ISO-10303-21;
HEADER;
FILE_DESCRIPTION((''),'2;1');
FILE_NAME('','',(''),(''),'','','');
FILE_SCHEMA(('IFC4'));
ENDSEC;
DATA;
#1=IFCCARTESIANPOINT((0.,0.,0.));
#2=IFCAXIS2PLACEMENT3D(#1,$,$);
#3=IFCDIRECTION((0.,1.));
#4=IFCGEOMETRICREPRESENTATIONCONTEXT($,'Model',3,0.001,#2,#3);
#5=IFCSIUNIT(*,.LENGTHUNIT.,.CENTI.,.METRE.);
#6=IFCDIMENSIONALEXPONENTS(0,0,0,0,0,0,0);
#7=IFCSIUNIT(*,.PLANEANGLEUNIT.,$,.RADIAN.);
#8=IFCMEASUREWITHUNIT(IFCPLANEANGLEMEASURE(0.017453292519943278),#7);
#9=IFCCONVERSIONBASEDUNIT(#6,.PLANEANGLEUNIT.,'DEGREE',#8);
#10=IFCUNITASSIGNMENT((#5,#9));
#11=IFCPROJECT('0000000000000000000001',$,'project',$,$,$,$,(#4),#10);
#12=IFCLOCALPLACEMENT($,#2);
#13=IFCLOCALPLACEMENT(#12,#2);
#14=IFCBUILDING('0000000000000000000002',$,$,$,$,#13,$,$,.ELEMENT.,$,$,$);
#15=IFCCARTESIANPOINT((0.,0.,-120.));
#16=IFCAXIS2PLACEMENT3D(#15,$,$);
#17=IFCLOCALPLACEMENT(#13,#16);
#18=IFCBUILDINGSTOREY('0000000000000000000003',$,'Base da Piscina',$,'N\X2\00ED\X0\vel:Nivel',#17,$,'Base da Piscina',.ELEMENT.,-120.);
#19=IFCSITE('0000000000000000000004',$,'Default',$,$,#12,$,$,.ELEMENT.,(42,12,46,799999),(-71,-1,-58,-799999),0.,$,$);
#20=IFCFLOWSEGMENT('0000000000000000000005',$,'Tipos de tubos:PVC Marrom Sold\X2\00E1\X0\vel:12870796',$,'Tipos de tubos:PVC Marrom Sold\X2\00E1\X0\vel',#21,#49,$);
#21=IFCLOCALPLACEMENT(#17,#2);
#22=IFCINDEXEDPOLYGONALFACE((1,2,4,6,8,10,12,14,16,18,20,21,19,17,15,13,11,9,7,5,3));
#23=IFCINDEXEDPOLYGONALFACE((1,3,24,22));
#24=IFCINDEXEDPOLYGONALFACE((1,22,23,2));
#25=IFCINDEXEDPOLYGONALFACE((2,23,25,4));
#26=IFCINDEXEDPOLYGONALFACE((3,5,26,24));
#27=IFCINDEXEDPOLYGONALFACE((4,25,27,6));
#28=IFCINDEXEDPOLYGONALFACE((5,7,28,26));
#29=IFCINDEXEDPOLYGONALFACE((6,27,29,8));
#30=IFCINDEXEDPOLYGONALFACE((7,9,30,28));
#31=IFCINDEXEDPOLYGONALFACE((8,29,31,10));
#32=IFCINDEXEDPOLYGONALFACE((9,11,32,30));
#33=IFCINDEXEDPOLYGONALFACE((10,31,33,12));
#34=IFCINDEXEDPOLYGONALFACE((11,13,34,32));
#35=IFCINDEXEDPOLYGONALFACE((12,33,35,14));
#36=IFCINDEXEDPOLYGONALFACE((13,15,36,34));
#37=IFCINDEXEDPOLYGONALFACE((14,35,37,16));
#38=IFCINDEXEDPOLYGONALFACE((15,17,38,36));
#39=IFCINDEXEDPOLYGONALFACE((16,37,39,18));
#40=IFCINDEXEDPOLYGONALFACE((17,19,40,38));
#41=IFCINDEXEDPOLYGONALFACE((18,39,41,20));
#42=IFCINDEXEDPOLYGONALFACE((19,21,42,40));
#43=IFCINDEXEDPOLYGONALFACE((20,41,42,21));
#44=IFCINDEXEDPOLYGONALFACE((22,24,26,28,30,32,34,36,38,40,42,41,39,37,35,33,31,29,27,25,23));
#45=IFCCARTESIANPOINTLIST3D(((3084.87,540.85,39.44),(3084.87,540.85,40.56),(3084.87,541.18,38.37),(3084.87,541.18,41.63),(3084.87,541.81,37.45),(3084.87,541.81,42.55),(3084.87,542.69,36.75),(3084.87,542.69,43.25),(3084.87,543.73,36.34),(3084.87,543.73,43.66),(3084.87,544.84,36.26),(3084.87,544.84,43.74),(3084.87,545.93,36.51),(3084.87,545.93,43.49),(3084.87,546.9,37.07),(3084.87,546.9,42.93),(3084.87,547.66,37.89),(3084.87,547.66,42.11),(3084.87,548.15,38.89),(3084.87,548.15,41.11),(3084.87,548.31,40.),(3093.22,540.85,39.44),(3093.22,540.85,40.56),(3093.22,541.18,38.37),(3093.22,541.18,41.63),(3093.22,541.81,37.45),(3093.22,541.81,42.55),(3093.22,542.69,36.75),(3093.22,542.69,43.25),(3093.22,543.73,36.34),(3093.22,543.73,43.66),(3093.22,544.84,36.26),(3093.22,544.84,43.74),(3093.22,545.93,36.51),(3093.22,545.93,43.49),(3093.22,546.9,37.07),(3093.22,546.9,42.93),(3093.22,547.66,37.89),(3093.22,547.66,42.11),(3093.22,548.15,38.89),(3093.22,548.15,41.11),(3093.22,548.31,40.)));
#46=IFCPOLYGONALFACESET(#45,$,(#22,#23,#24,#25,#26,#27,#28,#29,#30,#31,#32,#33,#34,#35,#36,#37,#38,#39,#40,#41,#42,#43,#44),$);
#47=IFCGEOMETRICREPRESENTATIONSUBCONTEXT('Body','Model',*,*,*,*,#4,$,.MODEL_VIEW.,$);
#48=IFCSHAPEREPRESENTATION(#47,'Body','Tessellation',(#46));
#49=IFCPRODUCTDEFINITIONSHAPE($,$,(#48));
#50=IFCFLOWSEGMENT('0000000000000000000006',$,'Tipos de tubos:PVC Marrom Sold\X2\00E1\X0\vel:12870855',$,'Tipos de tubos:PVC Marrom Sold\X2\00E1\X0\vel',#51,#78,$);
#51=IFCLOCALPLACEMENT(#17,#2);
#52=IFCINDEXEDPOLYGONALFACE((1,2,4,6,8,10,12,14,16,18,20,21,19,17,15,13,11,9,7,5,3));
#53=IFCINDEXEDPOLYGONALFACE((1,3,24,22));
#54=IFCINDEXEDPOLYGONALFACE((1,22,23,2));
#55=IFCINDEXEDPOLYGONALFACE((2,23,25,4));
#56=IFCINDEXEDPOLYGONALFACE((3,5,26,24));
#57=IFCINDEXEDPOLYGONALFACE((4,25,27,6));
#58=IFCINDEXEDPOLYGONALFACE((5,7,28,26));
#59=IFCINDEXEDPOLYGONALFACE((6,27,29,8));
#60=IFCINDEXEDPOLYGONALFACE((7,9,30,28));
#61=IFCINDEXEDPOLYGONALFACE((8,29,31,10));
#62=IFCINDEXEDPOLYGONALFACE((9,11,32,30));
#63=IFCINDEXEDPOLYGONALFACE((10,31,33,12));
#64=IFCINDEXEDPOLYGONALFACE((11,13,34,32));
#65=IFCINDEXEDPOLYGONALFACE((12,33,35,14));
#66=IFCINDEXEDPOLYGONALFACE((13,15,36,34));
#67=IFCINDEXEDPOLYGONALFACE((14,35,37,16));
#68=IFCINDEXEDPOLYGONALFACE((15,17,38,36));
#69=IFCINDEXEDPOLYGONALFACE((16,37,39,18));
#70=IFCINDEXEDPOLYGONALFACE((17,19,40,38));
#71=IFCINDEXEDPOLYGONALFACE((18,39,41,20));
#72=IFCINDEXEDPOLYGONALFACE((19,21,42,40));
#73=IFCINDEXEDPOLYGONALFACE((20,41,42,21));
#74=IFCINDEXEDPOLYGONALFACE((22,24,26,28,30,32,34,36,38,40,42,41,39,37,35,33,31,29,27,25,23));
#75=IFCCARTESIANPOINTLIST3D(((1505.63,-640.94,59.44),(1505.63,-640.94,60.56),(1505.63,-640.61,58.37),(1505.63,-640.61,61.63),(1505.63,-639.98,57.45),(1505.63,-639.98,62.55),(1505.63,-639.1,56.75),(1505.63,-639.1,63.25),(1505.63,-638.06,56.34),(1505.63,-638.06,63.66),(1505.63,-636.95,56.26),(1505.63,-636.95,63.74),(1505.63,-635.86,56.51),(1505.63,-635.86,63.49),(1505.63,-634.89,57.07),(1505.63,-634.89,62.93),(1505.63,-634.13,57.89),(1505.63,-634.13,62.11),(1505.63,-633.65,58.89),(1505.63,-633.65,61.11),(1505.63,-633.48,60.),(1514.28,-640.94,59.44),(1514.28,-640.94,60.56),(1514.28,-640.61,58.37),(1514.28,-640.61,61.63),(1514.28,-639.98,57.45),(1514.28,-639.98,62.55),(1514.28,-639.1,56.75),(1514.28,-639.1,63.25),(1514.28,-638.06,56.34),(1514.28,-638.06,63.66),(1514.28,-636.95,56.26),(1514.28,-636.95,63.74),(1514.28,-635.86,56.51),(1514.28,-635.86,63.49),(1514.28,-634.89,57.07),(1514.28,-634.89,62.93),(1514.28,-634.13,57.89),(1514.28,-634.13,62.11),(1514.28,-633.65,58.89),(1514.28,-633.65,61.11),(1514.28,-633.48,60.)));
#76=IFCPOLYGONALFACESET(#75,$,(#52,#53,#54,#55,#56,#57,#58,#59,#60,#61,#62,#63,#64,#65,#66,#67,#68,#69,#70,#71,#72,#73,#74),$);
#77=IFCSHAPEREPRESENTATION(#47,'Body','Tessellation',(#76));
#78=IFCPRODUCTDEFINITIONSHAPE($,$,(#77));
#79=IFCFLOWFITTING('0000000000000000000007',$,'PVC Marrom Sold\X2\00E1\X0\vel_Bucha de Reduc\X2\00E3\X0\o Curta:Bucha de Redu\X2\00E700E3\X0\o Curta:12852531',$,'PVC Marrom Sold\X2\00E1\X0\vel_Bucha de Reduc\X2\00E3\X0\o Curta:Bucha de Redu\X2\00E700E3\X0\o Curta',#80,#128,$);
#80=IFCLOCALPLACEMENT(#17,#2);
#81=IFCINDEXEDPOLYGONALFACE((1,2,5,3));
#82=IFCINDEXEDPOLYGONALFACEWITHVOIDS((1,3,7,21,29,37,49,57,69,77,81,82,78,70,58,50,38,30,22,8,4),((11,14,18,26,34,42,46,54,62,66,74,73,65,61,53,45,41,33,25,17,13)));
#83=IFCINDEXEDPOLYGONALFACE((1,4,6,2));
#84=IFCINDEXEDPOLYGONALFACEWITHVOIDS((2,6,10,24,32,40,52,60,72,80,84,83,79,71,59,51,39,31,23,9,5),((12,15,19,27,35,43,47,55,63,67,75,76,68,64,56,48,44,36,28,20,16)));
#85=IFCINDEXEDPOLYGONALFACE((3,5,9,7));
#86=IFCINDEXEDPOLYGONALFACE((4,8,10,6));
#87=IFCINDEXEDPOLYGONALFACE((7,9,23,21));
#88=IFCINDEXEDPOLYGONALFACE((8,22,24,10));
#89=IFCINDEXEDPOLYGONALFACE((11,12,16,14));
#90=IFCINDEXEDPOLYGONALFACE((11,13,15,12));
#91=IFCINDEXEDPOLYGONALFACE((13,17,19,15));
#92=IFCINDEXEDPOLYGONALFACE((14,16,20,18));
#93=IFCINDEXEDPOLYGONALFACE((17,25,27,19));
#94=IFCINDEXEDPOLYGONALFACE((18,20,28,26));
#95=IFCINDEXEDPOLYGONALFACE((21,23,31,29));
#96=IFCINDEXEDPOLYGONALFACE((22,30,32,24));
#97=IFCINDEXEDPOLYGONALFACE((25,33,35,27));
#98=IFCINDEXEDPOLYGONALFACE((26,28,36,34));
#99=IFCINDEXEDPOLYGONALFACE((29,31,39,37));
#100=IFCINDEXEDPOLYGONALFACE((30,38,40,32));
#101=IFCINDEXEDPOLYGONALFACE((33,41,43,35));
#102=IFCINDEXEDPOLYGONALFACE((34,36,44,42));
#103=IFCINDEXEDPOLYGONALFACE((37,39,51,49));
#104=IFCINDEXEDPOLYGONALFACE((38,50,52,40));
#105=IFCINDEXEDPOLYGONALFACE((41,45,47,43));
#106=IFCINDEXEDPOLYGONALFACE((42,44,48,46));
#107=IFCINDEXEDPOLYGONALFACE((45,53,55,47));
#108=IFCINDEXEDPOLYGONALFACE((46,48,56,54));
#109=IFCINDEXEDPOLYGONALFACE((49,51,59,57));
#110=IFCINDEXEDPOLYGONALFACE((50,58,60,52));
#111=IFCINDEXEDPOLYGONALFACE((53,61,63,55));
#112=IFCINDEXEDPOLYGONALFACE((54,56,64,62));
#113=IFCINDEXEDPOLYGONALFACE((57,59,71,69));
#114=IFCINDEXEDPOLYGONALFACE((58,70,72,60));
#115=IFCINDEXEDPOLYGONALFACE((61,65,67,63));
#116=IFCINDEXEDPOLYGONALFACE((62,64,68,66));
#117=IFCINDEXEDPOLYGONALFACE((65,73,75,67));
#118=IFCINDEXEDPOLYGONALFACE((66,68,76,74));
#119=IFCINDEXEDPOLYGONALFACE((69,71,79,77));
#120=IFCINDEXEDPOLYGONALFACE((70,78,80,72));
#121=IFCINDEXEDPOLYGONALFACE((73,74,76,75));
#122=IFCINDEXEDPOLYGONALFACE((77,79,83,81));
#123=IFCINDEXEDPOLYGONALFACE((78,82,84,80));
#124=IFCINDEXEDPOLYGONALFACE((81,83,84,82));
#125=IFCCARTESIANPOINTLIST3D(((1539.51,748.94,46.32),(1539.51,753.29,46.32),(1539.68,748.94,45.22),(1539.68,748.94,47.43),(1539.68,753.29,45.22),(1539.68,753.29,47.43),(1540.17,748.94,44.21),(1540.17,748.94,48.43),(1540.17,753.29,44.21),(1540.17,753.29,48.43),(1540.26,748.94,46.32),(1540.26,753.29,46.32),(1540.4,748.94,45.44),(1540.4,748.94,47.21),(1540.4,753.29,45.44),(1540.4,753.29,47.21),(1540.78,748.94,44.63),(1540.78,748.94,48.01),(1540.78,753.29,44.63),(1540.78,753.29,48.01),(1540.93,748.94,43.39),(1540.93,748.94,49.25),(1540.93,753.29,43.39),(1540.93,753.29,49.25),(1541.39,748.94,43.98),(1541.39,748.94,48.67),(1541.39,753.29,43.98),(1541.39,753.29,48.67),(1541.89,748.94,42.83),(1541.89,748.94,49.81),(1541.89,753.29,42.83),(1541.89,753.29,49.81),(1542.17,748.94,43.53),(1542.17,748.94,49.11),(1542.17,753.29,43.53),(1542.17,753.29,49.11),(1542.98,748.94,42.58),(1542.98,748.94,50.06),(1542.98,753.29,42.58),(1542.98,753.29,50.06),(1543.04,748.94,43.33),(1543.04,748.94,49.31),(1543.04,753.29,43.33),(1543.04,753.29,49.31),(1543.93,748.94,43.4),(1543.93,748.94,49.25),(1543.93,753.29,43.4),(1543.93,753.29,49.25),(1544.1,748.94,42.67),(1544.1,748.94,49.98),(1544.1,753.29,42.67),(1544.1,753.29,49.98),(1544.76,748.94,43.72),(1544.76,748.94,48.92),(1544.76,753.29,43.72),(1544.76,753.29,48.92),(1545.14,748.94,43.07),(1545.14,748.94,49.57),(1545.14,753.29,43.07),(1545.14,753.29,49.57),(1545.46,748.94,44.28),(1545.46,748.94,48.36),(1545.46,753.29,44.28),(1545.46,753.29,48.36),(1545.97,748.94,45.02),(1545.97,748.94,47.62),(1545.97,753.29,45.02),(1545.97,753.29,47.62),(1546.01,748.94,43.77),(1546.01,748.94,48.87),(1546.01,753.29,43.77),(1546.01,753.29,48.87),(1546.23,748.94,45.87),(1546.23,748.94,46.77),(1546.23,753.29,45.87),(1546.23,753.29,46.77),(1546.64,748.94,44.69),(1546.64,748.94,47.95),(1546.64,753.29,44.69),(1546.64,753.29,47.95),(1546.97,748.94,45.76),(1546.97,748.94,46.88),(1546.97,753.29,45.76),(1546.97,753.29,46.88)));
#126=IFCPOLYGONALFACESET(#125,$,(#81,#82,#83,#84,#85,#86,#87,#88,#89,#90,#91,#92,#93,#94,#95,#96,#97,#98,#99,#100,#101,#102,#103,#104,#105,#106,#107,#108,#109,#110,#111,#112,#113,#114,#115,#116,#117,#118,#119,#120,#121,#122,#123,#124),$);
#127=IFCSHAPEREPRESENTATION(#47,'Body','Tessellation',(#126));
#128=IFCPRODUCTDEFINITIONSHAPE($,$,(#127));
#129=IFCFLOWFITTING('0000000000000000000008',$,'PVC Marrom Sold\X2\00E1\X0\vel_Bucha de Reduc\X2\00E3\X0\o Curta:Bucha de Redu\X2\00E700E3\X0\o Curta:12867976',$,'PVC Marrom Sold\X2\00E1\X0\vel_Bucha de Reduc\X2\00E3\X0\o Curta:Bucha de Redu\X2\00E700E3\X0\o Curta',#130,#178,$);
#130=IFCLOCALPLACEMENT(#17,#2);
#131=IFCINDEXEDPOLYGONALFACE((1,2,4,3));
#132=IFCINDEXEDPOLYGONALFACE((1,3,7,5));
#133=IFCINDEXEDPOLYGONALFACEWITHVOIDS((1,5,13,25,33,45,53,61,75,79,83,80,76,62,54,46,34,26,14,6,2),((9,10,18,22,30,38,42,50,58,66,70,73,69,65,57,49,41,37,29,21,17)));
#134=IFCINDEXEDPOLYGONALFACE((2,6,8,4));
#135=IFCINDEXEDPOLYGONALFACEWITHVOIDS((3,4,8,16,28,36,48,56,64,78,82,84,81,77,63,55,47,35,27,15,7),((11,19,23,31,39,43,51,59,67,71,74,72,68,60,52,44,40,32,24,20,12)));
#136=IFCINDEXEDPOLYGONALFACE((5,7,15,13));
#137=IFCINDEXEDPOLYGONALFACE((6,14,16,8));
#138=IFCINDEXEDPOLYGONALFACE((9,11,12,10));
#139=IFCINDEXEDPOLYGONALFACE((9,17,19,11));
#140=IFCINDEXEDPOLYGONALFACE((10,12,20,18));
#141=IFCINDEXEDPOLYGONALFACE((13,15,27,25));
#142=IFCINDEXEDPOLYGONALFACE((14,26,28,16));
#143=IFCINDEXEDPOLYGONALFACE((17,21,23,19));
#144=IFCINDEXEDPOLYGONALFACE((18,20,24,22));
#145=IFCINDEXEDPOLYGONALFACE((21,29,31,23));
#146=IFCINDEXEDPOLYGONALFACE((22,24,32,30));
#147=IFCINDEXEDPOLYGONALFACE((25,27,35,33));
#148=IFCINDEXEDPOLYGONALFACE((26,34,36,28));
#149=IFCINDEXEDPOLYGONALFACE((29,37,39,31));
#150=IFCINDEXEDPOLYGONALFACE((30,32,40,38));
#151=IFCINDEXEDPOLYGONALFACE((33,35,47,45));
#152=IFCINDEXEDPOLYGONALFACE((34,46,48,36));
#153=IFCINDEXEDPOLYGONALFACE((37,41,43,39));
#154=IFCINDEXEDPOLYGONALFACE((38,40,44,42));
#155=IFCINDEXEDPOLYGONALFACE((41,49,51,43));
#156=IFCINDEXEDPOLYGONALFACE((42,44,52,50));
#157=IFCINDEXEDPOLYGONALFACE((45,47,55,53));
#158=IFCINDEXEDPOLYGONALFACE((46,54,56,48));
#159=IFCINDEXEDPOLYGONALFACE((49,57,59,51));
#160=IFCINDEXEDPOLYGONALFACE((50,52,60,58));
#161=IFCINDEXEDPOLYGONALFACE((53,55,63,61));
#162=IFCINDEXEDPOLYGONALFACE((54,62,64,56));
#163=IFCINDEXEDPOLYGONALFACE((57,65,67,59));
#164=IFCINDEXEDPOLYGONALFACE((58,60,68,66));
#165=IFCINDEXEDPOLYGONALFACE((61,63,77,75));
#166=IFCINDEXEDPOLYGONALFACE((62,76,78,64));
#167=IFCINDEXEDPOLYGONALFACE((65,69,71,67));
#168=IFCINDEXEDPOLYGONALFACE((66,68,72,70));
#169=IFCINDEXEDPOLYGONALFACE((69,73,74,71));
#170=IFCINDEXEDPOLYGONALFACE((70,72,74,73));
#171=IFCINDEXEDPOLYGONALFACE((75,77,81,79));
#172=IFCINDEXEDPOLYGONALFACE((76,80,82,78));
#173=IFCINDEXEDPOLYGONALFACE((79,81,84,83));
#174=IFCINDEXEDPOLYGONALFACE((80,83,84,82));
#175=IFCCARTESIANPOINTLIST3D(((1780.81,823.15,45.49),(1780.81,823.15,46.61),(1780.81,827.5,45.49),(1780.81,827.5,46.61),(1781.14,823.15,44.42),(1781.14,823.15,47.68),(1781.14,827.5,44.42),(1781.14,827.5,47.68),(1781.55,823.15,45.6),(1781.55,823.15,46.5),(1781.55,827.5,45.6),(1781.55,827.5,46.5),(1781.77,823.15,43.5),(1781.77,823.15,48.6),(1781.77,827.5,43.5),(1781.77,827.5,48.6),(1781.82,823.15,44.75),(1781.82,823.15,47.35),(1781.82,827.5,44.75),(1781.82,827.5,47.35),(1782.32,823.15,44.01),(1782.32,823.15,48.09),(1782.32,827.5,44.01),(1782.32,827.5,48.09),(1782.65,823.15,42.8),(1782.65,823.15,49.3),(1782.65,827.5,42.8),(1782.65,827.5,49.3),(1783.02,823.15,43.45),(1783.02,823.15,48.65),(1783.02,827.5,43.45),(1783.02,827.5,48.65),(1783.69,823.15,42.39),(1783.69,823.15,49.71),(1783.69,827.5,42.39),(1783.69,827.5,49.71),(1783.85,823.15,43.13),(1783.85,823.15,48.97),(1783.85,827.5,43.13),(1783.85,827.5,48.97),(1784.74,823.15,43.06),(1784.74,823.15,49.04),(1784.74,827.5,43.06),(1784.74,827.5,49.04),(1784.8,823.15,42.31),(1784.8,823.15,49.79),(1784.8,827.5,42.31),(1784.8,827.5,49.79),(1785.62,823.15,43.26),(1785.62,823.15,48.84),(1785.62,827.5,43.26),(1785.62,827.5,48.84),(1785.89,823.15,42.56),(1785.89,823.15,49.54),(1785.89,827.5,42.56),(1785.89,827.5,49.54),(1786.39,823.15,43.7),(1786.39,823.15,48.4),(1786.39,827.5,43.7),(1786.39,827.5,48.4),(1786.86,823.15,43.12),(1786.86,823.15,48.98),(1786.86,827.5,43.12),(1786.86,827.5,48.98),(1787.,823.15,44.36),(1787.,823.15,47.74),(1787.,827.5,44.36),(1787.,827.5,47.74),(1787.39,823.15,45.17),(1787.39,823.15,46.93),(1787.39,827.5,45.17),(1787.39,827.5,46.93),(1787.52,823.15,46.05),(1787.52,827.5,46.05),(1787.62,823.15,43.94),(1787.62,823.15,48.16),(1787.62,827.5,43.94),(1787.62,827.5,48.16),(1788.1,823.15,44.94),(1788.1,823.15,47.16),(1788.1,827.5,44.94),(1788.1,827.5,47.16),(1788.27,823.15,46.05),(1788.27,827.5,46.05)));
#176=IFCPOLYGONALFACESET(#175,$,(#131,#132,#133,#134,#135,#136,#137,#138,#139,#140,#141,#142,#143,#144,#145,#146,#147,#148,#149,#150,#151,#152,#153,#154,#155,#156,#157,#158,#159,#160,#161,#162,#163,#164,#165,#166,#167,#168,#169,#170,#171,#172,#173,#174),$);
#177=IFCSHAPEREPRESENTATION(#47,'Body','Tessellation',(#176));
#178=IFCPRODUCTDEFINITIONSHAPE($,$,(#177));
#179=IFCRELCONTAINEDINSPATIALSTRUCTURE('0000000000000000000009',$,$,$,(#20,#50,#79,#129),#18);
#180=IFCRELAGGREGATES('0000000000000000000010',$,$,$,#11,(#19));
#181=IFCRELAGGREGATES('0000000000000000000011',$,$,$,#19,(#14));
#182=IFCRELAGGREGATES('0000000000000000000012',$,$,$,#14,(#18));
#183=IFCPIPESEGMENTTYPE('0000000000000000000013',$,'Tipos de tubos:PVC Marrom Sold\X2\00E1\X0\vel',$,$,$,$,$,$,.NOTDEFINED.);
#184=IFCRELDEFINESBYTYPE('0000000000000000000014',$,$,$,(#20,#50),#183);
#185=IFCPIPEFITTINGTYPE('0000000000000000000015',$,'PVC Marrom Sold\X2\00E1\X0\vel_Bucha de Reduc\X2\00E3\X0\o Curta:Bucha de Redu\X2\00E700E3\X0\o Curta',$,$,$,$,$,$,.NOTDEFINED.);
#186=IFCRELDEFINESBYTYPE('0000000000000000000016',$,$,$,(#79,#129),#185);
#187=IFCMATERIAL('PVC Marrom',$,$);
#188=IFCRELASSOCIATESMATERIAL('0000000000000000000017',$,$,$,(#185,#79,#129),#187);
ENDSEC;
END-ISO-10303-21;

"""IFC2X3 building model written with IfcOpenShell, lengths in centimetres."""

from ifc_helpers import new_model, entity, si_unit, converted_unit, direction, frame, frame_2d, origin, origin_2d_with_axis, place, context, subcontext, project, spatial, circle, hollow_circle, extrude, source, transform, mapped, material, type_object, type_shapes, element, save


model = new_model("IFC2X3")

# Units and contexts
model_context = context("Model", 3, precision=0.001, world=origin(), true_north=direction((0.0, 1.0)))
body_context = subcontext(model_context, "Body", "Model", "MODEL_VIEW")
ifc_project = project(units=[si_unit("LENGTHUNIT", "METRE", prefix="CENTI"), converted_unit("PLANEANGLEUNIT", "DEGREE", entity("IfcPlaneAngleMeasure", 0.017453292519943278), si_unit("PLANEANGLEUNIT", "RADIAN"), dimensions=[0, 0, 0, 0, 0, 0, 0])], contexts=[model_context])

# Site, building, storey
site_placement = place(None, origin())
site = spatial("IfcSite", under=ifc_project, at=site_placement, Name="Default", CompositionType="ELEMENT", RefLatitude=(42, 12, 46, 799999), RefLongitude=(-71, -1, -58, -799999), RefElevation=0.0)
building_placement = place(site_placement, origin())
building = spatial("IfcBuilding", under=site, at=building_placement, CompositionType="ELEMENT")
storey_placement = place(building_placement, frame((0.0, 0.0, -120.0)))
storey = spatial("IfcBuildingStorey", under=building, at=storey_placement, Name="Base da Piscina", ObjectType="Nível:Nivel", LongName="Base da Piscina", CompositionType="ELEMENT", Elevation=-120.0)

# Flow segments
pipe_segment_type = type_object("IfcPipeSegmentType", Name="Tipos de tubos:PVC Marrom Soldável", PredefinedType="NOTDEFINED")
flow_segment_1_placement = place(storey_placement, origin())
element("IfcFlowSegment", 1, at=flow_segment_1_placement, inside=storey, type_object=pipe_segment_type, Name="Tipos de tubos:PVC Marrom Soldável:12870796", ObjectType="Tipos de tubos:PVC Marrom Soldável", context=body_context, shape_type="SweptSolid", body=[
    extrude(circle(Radius=3.75, at=origin_2d_with_axis()), frame((3084.87, 544.56, 40.0), z_axis=(1.0, 0.0, 0.0), x_axis=(0.0, 1.0, 0.0)), (0.0, 0.0, 1.0), 8.35),
])
flow_segment_2_placement = place(storey_placement, origin())
element("IfcFlowSegment", 2, at=flow_segment_2_placement, inside=storey, type_object=pipe_segment_type, Name="Tipos de tubos:PVC Marrom Soldável:12870855", ObjectType="Tipos de tubos:PVC Marrom Soldável", context=body_context, shape_type="SweptSolid", body=[
    extrude(circle(Radius=3.75, at=origin_2d_with_axis()), frame((1505.63, -637.23, 60.0), z_axis=(1.0, 0.0, 0.0), x_axis=(0.0, 1.0, 0.0)), (0.0, 0.0, 1.0), 8.65),
])

# Flow fittings
ifc_material_1 = material(Name="PVC Marrom")
pipe_fitting_type_1 = type_object("IfcPipeFittingType", Name="PVC Marrom Soldável_Bucha de Reducão Curta:Bucha de Redução Curta", PredefinedType="NOTDEFINED", material=ifc_material_1)
shared_shape_1 = source(origin(), body_context, "Body", "SweptSolid", [
    extrude(hollow_circle(Radius=3.75, WallThickness=0.75, at=frame_2d((0.0, 0.0), x_axis=(1.0, 0.0))), frame((0.0, 0.0, 0.0), z_axis=(1.0, 0.0, 0.0), x_axis=(0.0, 1.0, 0.0)), (0.0, 0.0, 1.0), 4.35),
])
type_shapes(pipe_fitting_type_1, [shared_shape_1])
for number, where, z_axis, x_axis, name in (
    (3, (1543.26, 748.94, 46.32), (0.0, 0.0, 1.0), (0.0, 1.0, 0.0), "PVC Marrom Soldável_Bucha de Reducão Curta:Bucha de Redução Curta:12852531"),
    (4, (1784.52, 827.5, 46.05), (0.0, 0.0, 1.0), (0.0, -1.0, 0.0), "PVC Marrom Soldável_Bucha de Reducão Curta:Bucha de Redução Curta:12867976"),
):
    element("IfcFlowFitting", number, at=place(storey_placement, frame(where, z_axis=z_axis, x_axis=x_axis)), inside=storey, type_object=pipe_fitting_type_1, material=ifc_material_1, Name=name, ObjectType="PVC Marrom Soldável_Bucha de Reducão Curta:Bucha de Redução Curta", context=body_context, shape_type="MappedRepresentation", body=[
        mapped(shared_shape_1, transform((0.0, 0.0, 0.0), scale=1.0)),
    ])

save(model, "model.ifc")
